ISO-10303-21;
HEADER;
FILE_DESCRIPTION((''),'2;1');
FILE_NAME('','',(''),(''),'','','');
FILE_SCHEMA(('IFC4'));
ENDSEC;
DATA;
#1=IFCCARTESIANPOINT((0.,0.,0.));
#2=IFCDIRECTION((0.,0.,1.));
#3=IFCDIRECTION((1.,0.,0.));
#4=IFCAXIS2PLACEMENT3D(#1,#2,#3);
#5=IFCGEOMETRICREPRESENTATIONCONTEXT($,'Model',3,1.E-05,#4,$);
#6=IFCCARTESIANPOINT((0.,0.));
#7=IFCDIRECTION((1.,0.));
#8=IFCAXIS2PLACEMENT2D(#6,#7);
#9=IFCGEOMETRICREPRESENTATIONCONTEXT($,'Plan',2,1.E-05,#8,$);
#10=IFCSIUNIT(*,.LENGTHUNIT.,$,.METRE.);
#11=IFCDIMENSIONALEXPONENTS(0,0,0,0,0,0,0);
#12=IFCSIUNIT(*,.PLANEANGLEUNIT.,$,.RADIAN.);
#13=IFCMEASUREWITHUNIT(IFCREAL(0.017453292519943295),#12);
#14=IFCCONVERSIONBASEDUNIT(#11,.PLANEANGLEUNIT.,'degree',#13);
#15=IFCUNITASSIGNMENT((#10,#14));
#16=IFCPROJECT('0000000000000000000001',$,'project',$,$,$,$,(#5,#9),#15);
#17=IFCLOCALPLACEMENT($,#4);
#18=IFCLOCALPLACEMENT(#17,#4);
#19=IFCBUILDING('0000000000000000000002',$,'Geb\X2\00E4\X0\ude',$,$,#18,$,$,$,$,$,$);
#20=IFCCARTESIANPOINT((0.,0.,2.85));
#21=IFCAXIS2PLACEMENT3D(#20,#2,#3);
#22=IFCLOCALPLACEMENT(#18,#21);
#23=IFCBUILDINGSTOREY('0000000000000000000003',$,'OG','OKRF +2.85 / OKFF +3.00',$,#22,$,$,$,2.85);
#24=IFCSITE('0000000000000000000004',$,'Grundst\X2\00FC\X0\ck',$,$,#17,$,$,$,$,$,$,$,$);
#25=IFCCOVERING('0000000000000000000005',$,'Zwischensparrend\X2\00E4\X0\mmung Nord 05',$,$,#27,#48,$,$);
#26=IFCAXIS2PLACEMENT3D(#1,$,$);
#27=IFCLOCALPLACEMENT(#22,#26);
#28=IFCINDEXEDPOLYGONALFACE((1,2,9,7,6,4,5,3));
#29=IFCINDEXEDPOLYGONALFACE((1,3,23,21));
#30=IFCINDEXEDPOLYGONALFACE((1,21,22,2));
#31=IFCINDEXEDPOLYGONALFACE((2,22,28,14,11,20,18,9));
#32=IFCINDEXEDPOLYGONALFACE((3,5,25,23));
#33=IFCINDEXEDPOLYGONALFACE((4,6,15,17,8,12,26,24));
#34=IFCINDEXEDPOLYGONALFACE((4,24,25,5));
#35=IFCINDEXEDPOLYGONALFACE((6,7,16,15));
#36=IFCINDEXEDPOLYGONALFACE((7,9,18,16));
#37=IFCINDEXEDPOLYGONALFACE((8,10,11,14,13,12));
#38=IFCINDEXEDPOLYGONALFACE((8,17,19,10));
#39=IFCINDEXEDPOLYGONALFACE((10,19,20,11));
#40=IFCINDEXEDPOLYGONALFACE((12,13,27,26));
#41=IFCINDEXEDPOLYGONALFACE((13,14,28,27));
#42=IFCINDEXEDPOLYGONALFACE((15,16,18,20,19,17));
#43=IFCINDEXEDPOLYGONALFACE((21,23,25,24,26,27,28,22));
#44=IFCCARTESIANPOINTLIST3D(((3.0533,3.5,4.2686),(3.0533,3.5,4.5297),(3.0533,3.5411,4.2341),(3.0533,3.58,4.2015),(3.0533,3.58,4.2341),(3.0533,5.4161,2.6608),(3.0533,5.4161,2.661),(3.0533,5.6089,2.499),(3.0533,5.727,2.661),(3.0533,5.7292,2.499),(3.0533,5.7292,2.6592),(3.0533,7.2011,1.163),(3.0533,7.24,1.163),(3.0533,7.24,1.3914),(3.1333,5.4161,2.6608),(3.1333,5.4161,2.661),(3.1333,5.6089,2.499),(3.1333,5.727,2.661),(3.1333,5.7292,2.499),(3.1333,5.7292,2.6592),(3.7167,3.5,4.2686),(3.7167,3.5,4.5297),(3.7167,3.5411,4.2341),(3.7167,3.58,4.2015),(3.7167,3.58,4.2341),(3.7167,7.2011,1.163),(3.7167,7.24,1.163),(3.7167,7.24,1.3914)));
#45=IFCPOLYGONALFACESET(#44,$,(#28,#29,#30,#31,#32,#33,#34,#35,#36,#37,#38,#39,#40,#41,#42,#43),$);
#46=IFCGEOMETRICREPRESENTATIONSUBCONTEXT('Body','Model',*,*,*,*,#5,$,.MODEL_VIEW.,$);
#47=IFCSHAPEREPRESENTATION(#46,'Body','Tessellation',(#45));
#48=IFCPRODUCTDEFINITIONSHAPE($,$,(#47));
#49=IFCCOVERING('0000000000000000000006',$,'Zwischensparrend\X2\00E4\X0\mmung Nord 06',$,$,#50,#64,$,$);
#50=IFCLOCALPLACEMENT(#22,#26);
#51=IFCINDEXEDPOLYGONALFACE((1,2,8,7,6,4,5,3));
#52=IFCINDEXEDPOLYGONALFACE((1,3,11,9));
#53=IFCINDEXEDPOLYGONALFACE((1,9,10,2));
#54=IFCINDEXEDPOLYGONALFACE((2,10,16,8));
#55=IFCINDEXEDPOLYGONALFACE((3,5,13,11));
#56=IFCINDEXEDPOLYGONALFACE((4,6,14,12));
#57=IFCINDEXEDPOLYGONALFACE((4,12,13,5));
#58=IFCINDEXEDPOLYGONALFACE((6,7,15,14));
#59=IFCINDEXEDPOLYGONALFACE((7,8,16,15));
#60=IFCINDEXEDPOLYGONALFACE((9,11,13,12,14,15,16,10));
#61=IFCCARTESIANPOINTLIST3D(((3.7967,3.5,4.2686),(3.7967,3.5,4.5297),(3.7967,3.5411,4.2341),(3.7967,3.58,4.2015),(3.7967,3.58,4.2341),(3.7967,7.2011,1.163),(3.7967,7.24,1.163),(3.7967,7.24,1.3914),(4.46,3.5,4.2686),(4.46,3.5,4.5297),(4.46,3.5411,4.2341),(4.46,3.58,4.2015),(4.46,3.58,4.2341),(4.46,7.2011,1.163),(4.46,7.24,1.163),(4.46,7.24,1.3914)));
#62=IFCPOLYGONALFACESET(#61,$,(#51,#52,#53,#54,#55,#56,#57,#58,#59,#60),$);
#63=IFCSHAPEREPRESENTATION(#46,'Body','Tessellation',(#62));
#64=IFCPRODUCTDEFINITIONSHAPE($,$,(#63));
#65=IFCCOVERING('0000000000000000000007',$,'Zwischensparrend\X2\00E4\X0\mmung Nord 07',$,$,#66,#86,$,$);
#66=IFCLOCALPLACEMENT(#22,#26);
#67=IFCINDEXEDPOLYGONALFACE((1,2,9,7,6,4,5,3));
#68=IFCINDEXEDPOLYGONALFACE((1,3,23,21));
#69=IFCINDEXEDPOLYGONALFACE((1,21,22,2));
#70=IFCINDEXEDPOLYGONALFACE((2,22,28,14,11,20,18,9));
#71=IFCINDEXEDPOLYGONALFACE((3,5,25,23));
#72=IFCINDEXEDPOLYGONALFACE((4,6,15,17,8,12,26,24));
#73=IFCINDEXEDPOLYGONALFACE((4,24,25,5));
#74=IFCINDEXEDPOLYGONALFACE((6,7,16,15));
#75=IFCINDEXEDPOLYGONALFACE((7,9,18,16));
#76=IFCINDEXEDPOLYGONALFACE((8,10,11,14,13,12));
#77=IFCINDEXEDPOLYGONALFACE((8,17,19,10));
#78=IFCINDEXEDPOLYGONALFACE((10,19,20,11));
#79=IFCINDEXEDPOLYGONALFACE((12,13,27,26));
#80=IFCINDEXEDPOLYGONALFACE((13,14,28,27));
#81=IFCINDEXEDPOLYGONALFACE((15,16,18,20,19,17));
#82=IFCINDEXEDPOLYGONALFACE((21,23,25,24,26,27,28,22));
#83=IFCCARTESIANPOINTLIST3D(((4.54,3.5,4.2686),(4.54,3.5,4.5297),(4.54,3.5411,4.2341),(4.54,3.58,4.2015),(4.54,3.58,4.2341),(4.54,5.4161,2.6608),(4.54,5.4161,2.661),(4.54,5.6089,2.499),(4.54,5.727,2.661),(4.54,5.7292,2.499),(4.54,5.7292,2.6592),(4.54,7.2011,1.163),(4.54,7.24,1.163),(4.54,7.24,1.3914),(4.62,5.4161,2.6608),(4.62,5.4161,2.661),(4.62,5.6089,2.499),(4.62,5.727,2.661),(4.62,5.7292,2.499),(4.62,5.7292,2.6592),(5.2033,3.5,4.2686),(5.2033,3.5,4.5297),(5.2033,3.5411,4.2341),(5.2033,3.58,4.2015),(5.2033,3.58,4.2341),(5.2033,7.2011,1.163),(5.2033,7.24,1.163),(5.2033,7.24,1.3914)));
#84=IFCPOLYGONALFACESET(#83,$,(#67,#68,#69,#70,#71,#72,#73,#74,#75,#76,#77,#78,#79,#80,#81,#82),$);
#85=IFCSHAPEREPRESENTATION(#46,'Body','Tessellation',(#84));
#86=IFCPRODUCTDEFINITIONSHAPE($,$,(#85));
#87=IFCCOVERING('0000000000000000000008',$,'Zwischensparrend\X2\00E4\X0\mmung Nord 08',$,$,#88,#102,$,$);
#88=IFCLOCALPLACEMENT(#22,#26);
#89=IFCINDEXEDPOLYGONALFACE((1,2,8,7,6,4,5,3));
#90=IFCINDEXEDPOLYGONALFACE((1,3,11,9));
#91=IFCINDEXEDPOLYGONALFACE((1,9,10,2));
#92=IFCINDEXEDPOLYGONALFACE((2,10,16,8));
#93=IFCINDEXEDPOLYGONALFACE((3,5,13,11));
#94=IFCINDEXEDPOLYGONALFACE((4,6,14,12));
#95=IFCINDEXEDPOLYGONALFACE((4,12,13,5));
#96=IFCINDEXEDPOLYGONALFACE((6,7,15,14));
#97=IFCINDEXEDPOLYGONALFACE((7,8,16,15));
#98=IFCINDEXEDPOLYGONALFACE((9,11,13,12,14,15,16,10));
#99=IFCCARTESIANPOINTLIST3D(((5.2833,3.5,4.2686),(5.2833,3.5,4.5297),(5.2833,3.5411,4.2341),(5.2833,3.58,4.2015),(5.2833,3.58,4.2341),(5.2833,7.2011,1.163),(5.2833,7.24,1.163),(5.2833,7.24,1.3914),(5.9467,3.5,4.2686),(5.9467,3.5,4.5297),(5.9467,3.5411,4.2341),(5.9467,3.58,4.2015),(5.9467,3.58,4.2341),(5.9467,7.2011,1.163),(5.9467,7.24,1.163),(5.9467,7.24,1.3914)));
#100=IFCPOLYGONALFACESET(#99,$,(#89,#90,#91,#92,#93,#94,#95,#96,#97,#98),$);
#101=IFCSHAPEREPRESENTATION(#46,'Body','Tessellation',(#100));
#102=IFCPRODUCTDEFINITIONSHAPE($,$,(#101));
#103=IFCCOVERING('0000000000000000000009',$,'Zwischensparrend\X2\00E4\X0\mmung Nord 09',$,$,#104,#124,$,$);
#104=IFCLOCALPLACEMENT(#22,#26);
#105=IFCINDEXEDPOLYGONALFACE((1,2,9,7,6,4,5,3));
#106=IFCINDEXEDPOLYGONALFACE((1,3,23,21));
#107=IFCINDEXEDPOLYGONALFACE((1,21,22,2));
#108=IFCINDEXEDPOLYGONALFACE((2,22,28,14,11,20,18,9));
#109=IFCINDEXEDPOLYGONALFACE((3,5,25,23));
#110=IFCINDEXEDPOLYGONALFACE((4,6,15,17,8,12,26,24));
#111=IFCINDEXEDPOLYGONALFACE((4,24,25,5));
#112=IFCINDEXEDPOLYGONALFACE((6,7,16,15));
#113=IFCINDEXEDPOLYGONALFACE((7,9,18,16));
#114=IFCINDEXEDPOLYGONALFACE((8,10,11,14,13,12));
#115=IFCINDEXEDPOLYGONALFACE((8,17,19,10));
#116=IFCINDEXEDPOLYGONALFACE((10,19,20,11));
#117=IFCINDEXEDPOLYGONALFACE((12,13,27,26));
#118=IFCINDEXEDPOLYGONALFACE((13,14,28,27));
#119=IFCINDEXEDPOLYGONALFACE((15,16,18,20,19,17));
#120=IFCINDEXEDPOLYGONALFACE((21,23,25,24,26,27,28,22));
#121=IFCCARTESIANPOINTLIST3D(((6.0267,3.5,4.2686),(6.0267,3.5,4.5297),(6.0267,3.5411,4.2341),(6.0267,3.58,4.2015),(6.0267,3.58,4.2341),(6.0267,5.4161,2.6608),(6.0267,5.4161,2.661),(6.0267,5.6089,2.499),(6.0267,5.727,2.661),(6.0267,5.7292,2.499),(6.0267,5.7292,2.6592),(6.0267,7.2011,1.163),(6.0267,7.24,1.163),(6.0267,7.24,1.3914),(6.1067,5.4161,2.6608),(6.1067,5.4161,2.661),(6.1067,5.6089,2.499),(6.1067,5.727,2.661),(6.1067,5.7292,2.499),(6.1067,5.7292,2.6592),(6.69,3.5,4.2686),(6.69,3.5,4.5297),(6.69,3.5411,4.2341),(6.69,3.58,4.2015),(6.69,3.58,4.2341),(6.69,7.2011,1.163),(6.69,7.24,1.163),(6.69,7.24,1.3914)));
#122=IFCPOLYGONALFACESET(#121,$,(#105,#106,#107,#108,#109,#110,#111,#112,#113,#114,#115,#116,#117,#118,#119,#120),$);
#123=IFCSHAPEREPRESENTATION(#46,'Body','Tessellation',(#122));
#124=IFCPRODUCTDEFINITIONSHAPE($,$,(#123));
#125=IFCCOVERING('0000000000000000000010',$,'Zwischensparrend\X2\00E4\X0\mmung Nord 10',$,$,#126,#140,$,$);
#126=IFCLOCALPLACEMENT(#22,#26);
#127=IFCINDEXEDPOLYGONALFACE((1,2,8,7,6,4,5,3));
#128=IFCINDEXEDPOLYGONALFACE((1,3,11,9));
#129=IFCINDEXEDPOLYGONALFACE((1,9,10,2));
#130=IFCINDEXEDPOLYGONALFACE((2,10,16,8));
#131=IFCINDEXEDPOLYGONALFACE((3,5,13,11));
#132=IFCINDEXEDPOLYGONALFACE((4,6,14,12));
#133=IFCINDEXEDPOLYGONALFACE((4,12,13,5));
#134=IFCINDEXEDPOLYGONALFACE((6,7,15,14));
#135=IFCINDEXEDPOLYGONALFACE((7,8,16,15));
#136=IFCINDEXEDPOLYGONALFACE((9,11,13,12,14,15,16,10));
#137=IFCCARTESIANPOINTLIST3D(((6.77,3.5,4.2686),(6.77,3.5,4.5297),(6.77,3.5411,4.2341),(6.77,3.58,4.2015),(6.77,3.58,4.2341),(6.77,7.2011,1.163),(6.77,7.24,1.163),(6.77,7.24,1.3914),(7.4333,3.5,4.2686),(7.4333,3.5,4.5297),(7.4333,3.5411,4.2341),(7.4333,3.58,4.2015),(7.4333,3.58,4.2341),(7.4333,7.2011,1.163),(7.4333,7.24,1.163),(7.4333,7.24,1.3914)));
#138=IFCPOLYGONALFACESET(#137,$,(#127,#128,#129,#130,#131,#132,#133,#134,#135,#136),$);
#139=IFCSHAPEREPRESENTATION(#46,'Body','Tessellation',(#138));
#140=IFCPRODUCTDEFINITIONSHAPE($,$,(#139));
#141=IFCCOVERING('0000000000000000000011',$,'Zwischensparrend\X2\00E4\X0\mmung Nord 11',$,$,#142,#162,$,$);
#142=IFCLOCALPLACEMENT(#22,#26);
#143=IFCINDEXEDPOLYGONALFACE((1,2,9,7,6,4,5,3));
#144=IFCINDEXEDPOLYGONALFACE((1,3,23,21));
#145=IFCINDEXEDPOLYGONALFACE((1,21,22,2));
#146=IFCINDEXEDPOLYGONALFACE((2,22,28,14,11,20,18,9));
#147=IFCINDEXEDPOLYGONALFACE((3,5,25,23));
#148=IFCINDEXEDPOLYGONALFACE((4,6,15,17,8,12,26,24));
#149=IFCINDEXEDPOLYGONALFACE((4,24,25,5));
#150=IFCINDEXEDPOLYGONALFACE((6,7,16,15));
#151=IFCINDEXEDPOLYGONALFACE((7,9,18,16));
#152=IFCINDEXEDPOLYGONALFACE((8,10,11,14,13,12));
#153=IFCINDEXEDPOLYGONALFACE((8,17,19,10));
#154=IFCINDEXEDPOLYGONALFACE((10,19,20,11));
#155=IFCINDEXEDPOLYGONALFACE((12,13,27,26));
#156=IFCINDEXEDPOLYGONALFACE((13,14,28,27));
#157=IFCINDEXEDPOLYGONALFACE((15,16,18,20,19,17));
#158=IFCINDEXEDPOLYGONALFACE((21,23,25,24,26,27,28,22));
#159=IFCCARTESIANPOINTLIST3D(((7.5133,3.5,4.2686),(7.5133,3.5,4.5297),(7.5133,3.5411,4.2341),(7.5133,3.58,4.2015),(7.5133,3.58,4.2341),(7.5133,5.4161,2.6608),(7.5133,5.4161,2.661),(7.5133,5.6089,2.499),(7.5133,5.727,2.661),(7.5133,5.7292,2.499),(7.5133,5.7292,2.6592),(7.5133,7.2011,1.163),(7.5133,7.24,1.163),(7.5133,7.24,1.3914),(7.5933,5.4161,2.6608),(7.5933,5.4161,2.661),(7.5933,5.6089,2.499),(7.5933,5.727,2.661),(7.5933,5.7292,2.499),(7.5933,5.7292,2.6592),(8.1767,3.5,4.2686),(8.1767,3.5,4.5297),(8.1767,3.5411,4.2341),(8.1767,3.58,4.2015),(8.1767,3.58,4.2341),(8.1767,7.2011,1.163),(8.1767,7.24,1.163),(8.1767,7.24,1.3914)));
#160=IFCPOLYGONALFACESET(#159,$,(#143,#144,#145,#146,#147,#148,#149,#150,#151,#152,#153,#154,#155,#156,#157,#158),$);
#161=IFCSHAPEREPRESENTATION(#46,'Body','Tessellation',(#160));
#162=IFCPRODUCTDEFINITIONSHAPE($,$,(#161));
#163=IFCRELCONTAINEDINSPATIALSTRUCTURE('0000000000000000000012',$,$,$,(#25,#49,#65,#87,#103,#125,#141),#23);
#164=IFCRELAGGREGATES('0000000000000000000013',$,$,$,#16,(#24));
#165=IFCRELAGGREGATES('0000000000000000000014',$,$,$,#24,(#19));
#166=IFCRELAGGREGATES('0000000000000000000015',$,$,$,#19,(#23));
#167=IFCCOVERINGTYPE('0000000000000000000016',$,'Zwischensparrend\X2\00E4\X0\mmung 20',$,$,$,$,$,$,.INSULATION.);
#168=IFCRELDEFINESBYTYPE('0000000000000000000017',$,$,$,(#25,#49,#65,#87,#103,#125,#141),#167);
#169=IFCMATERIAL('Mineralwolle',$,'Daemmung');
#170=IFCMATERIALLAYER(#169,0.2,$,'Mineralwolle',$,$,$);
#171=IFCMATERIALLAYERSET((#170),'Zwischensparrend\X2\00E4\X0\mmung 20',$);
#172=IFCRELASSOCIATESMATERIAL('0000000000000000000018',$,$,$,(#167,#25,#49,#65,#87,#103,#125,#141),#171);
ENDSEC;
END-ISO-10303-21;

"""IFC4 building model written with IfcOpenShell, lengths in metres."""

from ifc_helpers import new_model, entity, si_unit, converted_unit, frame, origin_with_axes, origin_2d_with_axis, place, context, subcontext, project, spatial, polyline, outline, extrude, material, layer, layer_set, layer_usage, type_object, element, save


model = new_model("IFC4")

# Units and contexts
model_context = context("Model", 3, precision=1e-05, world=origin_with_axes())
plan_context = context("Plan", 2, precision=1e-05, world=origin_2d_with_axis())
body_context = subcontext(model_context, "Body", "Model", "MODEL_VIEW")
ifc_project = project(units=[si_unit("LENGTHUNIT", "METRE"), converted_unit("PLANEANGLEUNIT", "degree", entity("IfcReal", 0.017453292519943295), si_unit("PLANEANGLEUNIT", "RADIAN"), dimensions=[0, 0, 0, 0, 0, 0, 0])], contexts=[model_context, plan_context])

# Site, building, storey
site_placement = place(None, origin_with_axes())
site = spatial("IfcSite", under=ifc_project, at=site_placement, Name="Grundstück")
building_placement = place(site_placement, origin_with_axes())
building = spatial("IfcBuilding", under=site, at=building_placement, Name="Gebäude")
storey_placement = place(building_placement, frame((0.0, 0.0, 2.85), z_axis=(0.0, 0.0, 1.0), x_axis=(1.0, 0.0, 0.0)))
storey = spatial("IfcBuildingStorey", under=building, at=storey_placement, Name="OG", Description="OKRF +2.85 / OKFF +3.00", Elevation=2.85)

# Covering, opening
ifc_material_1 = material(Name="Mineralwolle", Category="Daemmung")
ifc_layer_1 = layer(ifc_material_1, 0.2, Name="Mineralwolle")
ifc_layer_set_1 = layer_set([ifc_layer_1], Name="Zwischensparrendämmung 20")
ifc_layer_usage_1 = layer_usage(ifc_layer_set_1, "AXIS3", "POSITIVE", 0.0)
covering_type_1 = type_object("IfcCoveringType", Name="Zwischensparrendämmung 20", PredefinedType="INSULATION", material=ifc_layer_set_1)
covering_1_placement = place(storey_placement, frame((3.7167, 7.24, 1.1304), z_axis=(0.0, 0.642788, 0.766044), x_axis=(-1.0, 0.0, 0.0)))
covering_1 = element("IfcCovering", 1, at=covering_1_placement, inside=storey, type_object=covering_type_1, material=ifc_layer_usage_1, Name="Zwischensparrendämmung Nord 05", context=body_context, shape_type="SweptSolid", body=[
    extrude(outline(polyline([(0.021, 0.025), (0.0508, 0.0), (4.7778, 0.0), (4.7988, 0.025), (4.8286, 0.0), (4.8822, 0.0), (5.05, 0.2), (0.1678, 0.2), (0.021, 0.025)])), frame((0.0, 0.0, 0.0), z_axis=(1.0, 0.0, 0.0), x_axis=(0.0, 1.0, 0.0)), (0.0, 0.0, 1.0), 0.6633),
])
opening_1_placement = place(covering_1_placement, frame((3.7167, 2.9876, -7.7029), z_axis=(0.0, 0.642788, 0.766044), x_axis=(-1.0, 0.0, 0.0)))
element("IfcOpeningElement", 2, at=opening_1_placement, cuts=covering_1, PredefinedType="RECESS", context=body_context, shape_type="SweptSolid", body=[
    extrude(outline(polyline([(3.0533, 5.4161), (3.1333, 5.4161), (3.1333, 5.7292), (3.0533, 5.7292), (3.0533, 5.4161)])), frame((0.0, 0.0, 5.349), z_axis=(0.0, 0.0, 1.0), x_axis=(1.0, 0.0, 0.0)), (0.0, 0.0, 1.0), 0.162),
])

# Covering
ifc_layer_usage_2 = layer_usage(ifc_layer_set_1, "AXIS3", "POSITIVE", 0.0)
covering_2_placement = place(storey_placement, frame((4.46, 7.24, 1.1304), z_axis=(0.0, 0.642788, 0.766044), x_axis=(-1.0, 0.0, 0.0)))
element("IfcCovering", 3, at=covering_2_placement, inside=storey, type_object=covering_type_1, material=ifc_layer_usage_2, Name="Zwischensparrendämmung Nord 06", context=body_context, shape_type="SweptSolid", body=[
    extrude(outline(polyline([(0.021, 0.025), (0.0508, 0.0), (4.7778, 0.0), (4.7988, 0.025), (4.8286, 0.0), (4.8822, 0.0), (5.05, 0.2), (0.1678, 0.2), (0.021, 0.025)])), frame((0.0, 0.0, 0.0), z_axis=(1.0, 0.0, 0.0), x_axis=(0.0, 1.0, 0.0)), (0.0, 0.0, 1.0), 0.6633),
])

# Covering, opening
ifc_layer_usage_3 = layer_usage(ifc_layer_set_1, "AXIS3", "POSITIVE", 0.0)
covering_3_placement = place(storey_placement, frame((5.2033, 7.24, 1.1304), z_axis=(0.0, 0.642788, 0.766044), x_axis=(-1.0, 0.0, 0.0)))
covering_3 = element("IfcCovering", 4, at=covering_3_placement, inside=storey, type_object=covering_type_1, material=ifc_layer_usage_3, Name="Zwischensparrendämmung Nord 07", context=body_context, shape_type="SweptSolid", body=[
    extrude(outline(polyline([(0.021, 0.025), (0.0508, 0.0), (4.7778, 0.0), (4.7988, 0.025), (4.8286, 0.0), (4.8822, 0.0), (5.05, 0.2), (0.1678, 0.2), (0.021, 0.025)])), frame((0.0, 0.0, 0.0), z_axis=(1.0, 0.0, 0.0), x_axis=(0.0, 1.0, 0.0)), (0.0, 0.0, 1.0), 0.6633),
])
opening_2_placement = place(covering_3_placement, frame((5.2033, 2.9876, -7.7029), z_axis=(0.0, 0.642788, 0.766044), x_axis=(-1.0, 0.0, 0.0)))
element("IfcOpeningElement", 5, at=opening_2_placement, cuts=covering_3, PredefinedType="RECESS", context=body_context, shape_type="SweptSolid", body=[
    extrude(outline(polyline([(4.54, 5.4161), (4.62, 5.4161), (4.62, 5.7292), (4.54, 5.7292), (4.54, 5.4161)])), frame((0.0, 0.0, 5.349), z_axis=(0.0, 0.0, 1.0), x_axis=(1.0, 0.0, 0.0)), (0.0, 0.0, 1.0), 0.162),
])

# Covering
ifc_layer_usage_4 = layer_usage(ifc_layer_set_1, "AXIS3", "POSITIVE", 0.0)
covering_4_placement = place(storey_placement, frame((5.9467, 7.24, 1.1304), z_axis=(0.0, 0.642788, 0.766044), x_axis=(-1.0, 0.0, 0.0)))
element("IfcCovering", 6, at=covering_4_placement, inside=storey, type_object=covering_type_1, material=ifc_layer_usage_4, Name="Zwischensparrendämmung Nord 08", context=body_context, shape_type="SweptSolid", body=[
    extrude(outline(polyline([(0.021, 0.025), (0.0508, 0.0), (4.7778, 0.0), (4.7988, 0.025), (4.8286, 0.0), (4.8822, 0.0), (5.05, 0.2), (0.1678, 0.2), (0.021, 0.025)])), frame((0.0, 0.0, 0.0), z_axis=(1.0, 0.0, 0.0), x_axis=(0.0, 1.0, 0.0)), (0.0, 0.0, 1.0), 0.6633),
])

# Covering, opening
ifc_layer_usage_5 = layer_usage(ifc_layer_set_1, "AXIS3", "POSITIVE", 0.0)
covering_5_placement = place(storey_placement, frame((6.69, 7.24, 1.1304), z_axis=(0.0, 0.642788, 0.766044), x_axis=(-1.0, 0.0, 0.0)))
covering_5 = element("IfcCovering", 7, at=covering_5_placement, inside=storey, type_object=covering_type_1, material=ifc_layer_usage_5, Name="Zwischensparrendämmung Nord 09", context=body_context, shape_type="SweptSolid", body=[
    extrude(outline(polyline([(0.021, 0.025), (0.0508, 0.0), (4.7778, 0.0), (4.7988, 0.025), (4.8286, 0.0), (4.8822, 0.0), (5.05, 0.2), (0.1678, 0.2), (0.021, 0.025)])), frame((0.0, 0.0, 0.0), z_axis=(1.0, 0.0, 0.0), x_axis=(0.0, 1.0, 0.0)), (0.0, 0.0, 1.0), 0.6633),
])
opening_3_placement = place(covering_5_placement, frame((6.69, 2.9876, -7.7029), z_axis=(0.0, 0.642788, 0.766044), x_axis=(-1.0, 0.0, 0.0)))
element("IfcOpeningElement", 8, at=opening_3_placement, cuts=covering_5, PredefinedType="RECESS", context=body_context, shape_type="SweptSolid", body=[
    extrude(outline(polyline([(6.0267, 5.4161), (6.1067, 5.4161), (6.1067, 5.7292), (6.0267, 5.7292), (6.0267, 5.4161)])), frame((0.0, 0.0, 5.349), z_axis=(0.0, 0.0, 1.0), x_axis=(1.0, 0.0, 0.0)), (0.0, 0.0, 1.0), 0.162),
])

# Covering
ifc_layer_usage_6 = layer_usage(ifc_layer_set_1, "AXIS3", "POSITIVE", 0.0)
covering_6_placement = place(storey_placement, frame((7.4333, 7.24, 1.1304), z_axis=(0.0, 0.642788, 0.766044), x_axis=(-1.0, 0.0, 0.0)))
element("IfcCovering", 9, at=covering_6_placement, inside=storey, type_object=covering_type_1, material=ifc_layer_usage_6, Name="Zwischensparrendämmung Nord 10", context=body_context, shape_type="SweptSolid", body=[
    extrude(outline(polyline([(0.021, 0.025), (0.0508, 0.0), (4.7778, 0.0), (4.7988, 0.025), (4.8286, 0.0), (4.8822, 0.0), (5.05, 0.2), (0.1678, 0.2), (0.021, 0.025)])), frame((0.0, 0.0, 0.0), z_axis=(1.0, 0.0, 0.0), x_axis=(0.0, 1.0, 0.0)), (0.0, 0.0, 1.0), 0.6633),
])

# Covering, opening
ifc_layer_usage_7 = layer_usage(ifc_layer_set_1, "AXIS3", "POSITIVE", 0.0)
covering_7_placement = place(storey_placement, frame((8.1767, 7.24, 1.1304), z_axis=(0.0, 0.642788, 0.766044), x_axis=(-1.0, 0.0, 0.0)))
covering_7 = element("IfcCovering", 10, at=covering_7_placement, inside=storey, type_object=covering_type_1, material=ifc_layer_usage_7, Name="Zwischensparrendämmung Nord 11", context=body_context, shape_type="SweptSolid", body=[
    extrude(outline(polyline([(0.021, 0.025), (0.0508, 0.0), (4.7778, 0.0), (4.7988, 0.025), (4.8286, 0.0), (4.8822, 0.0), (5.05, 0.2), (0.1678, 0.2), (0.021, 0.025)])), frame((0.0, 0.0, 0.0), z_axis=(1.0, 0.0, 0.0), x_axis=(0.0, 1.0, 0.0)), (0.0, 0.0, 1.0), 0.6633),
])
opening_4_placement = place(covering_7_placement, frame((8.1767, 2.9876, -7.7029), z_axis=(0.0, 0.642788, 0.766044), x_axis=(-1.0, 0.0, 0.0)))
element("IfcOpeningElement", 11, at=opening_4_placement, cuts=covering_7, PredefinedType="RECESS", context=body_context, shape_type="SweptSolid", body=[
    extrude(outline(polyline([(7.5133, 5.4161), (7.5933, 5.4161), (7.5933, 5.7292), (7.5133, 5.7292), (7.5133, 5.4161)])), frame((0.0, 0.0, 5.349), z_axis=(0.0, 0.0, 1.0), x_axis=(1.0, 0.0, 0.0)), (0.0, 0.0, 1.0), 0.162),
])

save(model, "model.ifc")
